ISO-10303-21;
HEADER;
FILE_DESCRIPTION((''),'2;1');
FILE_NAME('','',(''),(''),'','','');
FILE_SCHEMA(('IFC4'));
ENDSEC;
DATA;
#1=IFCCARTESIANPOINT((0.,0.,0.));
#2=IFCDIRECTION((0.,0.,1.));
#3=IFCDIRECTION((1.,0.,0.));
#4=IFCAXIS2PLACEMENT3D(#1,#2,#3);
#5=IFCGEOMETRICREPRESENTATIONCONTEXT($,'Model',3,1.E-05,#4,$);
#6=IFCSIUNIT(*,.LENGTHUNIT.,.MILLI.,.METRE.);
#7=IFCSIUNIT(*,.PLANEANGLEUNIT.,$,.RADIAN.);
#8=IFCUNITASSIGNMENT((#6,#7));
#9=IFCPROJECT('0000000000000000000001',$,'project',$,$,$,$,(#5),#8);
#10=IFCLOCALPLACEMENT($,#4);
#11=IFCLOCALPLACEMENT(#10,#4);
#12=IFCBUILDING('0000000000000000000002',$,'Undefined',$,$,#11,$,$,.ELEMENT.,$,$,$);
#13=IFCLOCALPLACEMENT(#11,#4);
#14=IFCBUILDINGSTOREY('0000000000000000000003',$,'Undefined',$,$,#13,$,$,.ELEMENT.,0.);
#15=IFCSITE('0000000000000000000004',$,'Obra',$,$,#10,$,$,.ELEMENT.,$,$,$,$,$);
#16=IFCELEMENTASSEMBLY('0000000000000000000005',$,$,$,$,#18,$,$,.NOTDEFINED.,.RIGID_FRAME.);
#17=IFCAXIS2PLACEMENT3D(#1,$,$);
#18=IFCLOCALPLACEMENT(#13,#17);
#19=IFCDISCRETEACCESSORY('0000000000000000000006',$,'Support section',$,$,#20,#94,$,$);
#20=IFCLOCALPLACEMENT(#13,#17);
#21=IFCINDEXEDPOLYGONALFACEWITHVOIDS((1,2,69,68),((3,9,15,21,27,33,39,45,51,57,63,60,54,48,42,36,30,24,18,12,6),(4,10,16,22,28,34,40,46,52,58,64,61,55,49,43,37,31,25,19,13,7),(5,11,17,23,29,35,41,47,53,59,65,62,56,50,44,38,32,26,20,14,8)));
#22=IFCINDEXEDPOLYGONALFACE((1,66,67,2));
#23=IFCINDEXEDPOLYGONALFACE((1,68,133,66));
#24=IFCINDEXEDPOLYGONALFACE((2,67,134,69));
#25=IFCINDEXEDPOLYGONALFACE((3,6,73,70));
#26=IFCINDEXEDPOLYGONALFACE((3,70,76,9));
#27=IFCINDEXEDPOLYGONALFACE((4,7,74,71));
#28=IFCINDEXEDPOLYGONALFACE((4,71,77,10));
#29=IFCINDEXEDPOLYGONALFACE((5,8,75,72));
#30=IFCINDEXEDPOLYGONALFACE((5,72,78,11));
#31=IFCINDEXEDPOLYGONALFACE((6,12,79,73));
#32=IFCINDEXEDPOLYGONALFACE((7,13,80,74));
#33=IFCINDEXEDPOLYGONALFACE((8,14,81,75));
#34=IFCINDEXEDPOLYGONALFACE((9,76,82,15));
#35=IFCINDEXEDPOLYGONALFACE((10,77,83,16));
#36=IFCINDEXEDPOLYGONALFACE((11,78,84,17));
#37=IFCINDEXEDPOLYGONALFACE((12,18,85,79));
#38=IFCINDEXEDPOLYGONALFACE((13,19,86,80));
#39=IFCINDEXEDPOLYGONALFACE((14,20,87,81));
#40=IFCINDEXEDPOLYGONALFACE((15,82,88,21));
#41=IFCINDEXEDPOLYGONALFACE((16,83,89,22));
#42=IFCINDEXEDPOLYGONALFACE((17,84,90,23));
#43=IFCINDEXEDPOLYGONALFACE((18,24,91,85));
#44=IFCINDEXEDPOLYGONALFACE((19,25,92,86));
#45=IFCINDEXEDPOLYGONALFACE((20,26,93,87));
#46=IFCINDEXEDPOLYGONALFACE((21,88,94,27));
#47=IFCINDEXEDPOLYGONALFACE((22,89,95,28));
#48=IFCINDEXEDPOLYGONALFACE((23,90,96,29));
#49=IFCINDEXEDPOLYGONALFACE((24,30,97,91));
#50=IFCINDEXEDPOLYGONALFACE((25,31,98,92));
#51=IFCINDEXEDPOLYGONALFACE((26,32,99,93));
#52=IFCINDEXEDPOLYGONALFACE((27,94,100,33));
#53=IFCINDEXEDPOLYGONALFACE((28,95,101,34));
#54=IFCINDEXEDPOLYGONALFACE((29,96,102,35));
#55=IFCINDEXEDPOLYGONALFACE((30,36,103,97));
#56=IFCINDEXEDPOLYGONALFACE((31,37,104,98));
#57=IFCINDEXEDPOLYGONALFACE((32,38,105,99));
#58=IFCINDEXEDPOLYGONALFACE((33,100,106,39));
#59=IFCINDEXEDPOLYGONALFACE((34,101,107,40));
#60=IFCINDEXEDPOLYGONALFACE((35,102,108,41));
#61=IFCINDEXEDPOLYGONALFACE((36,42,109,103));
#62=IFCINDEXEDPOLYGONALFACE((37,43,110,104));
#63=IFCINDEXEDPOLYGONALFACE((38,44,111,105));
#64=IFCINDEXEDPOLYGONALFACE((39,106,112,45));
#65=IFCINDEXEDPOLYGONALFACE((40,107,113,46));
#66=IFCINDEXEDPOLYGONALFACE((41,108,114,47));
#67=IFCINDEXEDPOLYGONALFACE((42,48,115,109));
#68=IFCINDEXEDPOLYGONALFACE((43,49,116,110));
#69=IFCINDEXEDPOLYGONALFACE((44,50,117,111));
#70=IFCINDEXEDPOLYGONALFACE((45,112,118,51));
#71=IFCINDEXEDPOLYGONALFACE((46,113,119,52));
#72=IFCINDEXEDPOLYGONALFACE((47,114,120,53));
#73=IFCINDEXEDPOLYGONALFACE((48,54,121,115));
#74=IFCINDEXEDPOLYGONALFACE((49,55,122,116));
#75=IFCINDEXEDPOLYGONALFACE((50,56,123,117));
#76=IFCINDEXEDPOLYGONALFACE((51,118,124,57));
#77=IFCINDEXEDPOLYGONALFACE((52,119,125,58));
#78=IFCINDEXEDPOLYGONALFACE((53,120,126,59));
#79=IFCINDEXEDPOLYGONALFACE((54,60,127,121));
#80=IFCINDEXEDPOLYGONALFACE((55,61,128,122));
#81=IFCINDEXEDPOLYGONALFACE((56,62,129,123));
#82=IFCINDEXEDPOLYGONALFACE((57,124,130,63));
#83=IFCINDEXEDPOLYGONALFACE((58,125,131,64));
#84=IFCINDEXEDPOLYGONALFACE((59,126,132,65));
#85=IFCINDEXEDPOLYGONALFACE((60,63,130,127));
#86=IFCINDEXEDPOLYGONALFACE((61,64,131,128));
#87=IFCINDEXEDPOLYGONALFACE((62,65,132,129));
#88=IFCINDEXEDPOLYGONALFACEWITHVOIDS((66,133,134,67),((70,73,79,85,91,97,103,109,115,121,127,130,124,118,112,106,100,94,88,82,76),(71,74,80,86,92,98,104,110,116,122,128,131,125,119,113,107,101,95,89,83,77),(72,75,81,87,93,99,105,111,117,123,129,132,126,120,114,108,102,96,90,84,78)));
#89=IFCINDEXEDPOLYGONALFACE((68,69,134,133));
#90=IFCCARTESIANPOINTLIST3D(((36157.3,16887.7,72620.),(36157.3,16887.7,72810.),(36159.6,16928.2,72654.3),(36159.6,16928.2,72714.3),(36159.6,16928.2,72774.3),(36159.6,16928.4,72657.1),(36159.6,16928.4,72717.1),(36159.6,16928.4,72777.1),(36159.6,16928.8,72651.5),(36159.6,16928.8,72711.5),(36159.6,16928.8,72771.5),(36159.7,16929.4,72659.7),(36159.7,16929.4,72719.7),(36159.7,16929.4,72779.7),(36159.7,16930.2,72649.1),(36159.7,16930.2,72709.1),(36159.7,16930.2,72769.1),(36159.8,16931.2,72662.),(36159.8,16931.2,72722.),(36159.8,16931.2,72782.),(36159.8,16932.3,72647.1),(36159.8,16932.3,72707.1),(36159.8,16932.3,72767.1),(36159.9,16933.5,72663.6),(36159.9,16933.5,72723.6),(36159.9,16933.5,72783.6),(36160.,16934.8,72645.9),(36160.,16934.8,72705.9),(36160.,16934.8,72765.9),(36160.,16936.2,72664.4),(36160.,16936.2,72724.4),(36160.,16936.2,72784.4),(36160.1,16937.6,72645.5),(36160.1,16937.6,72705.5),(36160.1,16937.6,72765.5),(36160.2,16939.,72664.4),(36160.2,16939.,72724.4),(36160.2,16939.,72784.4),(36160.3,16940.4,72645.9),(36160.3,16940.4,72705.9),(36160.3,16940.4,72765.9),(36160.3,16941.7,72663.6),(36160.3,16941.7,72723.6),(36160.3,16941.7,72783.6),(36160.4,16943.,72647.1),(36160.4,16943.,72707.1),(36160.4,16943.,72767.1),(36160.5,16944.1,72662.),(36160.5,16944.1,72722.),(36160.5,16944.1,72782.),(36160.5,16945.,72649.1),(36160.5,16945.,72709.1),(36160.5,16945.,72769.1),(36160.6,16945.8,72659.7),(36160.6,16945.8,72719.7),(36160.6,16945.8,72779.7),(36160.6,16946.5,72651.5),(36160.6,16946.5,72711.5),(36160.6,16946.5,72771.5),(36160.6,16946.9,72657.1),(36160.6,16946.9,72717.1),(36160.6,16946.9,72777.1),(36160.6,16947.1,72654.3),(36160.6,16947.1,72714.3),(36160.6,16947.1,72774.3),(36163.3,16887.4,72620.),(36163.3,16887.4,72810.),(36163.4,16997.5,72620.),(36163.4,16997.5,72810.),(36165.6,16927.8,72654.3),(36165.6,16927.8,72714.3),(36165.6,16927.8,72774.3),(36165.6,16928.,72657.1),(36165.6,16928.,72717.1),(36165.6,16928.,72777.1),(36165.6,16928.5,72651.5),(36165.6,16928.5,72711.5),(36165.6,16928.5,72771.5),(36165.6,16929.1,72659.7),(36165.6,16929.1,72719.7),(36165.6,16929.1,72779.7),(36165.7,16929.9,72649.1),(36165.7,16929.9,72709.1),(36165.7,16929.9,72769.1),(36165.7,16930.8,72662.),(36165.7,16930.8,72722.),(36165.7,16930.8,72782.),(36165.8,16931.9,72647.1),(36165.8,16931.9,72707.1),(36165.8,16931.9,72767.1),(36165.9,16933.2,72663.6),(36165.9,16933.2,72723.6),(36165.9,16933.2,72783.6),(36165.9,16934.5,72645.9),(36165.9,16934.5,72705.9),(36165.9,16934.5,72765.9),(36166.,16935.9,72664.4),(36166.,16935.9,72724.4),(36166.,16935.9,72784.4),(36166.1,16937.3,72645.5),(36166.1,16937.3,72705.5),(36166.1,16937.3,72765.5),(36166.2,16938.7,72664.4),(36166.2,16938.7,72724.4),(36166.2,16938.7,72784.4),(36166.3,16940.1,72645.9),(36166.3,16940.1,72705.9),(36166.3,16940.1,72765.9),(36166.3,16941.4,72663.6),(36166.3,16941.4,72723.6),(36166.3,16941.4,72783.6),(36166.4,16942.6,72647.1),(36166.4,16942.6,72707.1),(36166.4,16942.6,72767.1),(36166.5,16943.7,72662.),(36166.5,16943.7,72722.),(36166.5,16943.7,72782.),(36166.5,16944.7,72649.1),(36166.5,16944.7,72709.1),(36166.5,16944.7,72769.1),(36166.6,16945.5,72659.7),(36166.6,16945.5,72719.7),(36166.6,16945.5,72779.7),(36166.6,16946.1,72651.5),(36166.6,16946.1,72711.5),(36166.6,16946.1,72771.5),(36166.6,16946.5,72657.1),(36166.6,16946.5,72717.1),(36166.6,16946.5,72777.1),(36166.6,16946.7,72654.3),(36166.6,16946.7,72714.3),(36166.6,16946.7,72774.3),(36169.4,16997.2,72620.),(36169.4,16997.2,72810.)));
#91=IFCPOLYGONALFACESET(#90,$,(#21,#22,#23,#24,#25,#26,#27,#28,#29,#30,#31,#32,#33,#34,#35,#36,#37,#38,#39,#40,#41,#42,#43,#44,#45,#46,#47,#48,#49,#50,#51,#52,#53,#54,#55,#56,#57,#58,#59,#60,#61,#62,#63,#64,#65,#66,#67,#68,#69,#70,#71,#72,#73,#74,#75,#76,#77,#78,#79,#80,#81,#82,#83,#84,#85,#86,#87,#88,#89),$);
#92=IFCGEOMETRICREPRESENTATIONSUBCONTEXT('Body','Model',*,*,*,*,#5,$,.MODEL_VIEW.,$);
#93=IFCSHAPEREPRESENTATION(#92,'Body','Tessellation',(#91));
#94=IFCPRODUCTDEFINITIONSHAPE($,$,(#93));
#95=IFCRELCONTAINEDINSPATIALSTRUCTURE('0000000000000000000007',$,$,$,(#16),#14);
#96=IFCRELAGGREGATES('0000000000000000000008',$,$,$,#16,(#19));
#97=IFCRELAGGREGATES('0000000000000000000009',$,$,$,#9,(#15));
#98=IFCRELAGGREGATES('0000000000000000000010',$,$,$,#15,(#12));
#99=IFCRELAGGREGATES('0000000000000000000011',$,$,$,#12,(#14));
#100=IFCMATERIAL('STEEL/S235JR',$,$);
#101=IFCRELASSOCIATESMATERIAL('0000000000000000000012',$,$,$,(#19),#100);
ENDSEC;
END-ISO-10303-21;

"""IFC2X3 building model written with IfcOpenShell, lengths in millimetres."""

from ifc_helpers import new_model, si_unit, frame, origin_with_axes, origin_2d_with_axis, place, context, subcontext, project, spatial, rectangle, circle, extrude, source, transform, mapped, material, element, aggregate, save


model = new_model("IFC2X3")

# Units and contexts
model_context = context("Model", 3, precision=1e-05, world=origin_with_axes())
body_context = subcontext(model_context, "Body", "Model", "MODEL_VIEW")
ifc_project = project(units=[si_unit("LENGTHUNIT", "METRE", prefix="MILLI"), si_unit("PLANEANGLEUNIT", "RADIAN")], contexts=[model_context])

# Site, building, storey
site_placement = place(None, origin_with_axes())
site = spatial("IfcSite", under=ifc_project, at=site_placement, Name="Obra", CompositionType="ELEMENT")
building_placement = place(site_placement, origin_with_axes())
building = spatial("IfcBuilding", under=site, at=building_placement, Name="Undefined", CompositionType="ELEMENT")
storey_placement = place(building_placement, origin_with_axes())
storey = spatial("IfcBuildingStorey", under=building, at=storey_placement, Name="Undefined", CompositionType="ELEMENT", Elevation=0.0)

# Element assembly
ifc_material = material(Name="STEEL/S235JR")
assembly_1_placement = place(storey_placement, origin_with_axes())
assembly_1 = element("IfcElementAssembly", 1, at=assembly_1_placement, inside=storey, AssemblyPlace="NOTDEFINED", PredefinedType="RIGID_FRAME")

# Discrete accessory, opening
shared_shape_1 = source(origin_with_axes(), body_context, "Body", "SweptSolid", [
    extrude(circle(Radius=9.5, at=origin_2d_with_axis()), frame((0.0, -9.2, 0.0), z_axis=(0.0, 1.0, 0.0), x_axis=(1.0, 0.0, 0.0)), (0.0, 0.0, 1.0), 6.2),
])
discrete_accessory_1_placement = place(assembly_1_placement, frame((36163.4, 16942.4, 72620.0), z_axis=(0.0, 0.0, 1.0), x_axis=(0.055268, 0.998472, 0.0)))
discrete_accessory_1 = element("IfcDiscreteAccessory", 2, at=discrete_accessory_1_placement, material=ifc_material, Name="Support section", context=body_context, shape_type="SweptSolid", body=[
    extrude(rectangle(XDim=6.0, YDim=110.0, at=origin_2d_with_axis()), frame((0.0, 0.0, 190.0), z_axis=(0.0, 0.0, -1.0), x_axis=(0.0, 1.0, 0.0)), (0.0, 0.0, 1.0), 190.0),
])
opening_1_placement = place(assembly_1_placement, frame((36172.0, 16987.0, 72835.0), z_axis=(-0.055268, -0.998472, 0.0), x_axis=(0.0, 0.0, -1.0)))
element("IfcOpeningElement", 3, at=opening_1_placement, cuts=discrete_accessory_1, ObjectType="Opening", context=body_context, shape_type="MappedRepresentation", body=[
    mapped(shared_shape_1, transform((60.0, 0.0, 50.0))),
    mapped(shared_shape_1, transform((120.0, 0.0, 50.0))),
    mapped(shared_shape_1, transform((180.0, 0.0, 50.0))),
])
aggregate(assembly_1, [discrete_accessory_1])

save(model, "model.ifc")
